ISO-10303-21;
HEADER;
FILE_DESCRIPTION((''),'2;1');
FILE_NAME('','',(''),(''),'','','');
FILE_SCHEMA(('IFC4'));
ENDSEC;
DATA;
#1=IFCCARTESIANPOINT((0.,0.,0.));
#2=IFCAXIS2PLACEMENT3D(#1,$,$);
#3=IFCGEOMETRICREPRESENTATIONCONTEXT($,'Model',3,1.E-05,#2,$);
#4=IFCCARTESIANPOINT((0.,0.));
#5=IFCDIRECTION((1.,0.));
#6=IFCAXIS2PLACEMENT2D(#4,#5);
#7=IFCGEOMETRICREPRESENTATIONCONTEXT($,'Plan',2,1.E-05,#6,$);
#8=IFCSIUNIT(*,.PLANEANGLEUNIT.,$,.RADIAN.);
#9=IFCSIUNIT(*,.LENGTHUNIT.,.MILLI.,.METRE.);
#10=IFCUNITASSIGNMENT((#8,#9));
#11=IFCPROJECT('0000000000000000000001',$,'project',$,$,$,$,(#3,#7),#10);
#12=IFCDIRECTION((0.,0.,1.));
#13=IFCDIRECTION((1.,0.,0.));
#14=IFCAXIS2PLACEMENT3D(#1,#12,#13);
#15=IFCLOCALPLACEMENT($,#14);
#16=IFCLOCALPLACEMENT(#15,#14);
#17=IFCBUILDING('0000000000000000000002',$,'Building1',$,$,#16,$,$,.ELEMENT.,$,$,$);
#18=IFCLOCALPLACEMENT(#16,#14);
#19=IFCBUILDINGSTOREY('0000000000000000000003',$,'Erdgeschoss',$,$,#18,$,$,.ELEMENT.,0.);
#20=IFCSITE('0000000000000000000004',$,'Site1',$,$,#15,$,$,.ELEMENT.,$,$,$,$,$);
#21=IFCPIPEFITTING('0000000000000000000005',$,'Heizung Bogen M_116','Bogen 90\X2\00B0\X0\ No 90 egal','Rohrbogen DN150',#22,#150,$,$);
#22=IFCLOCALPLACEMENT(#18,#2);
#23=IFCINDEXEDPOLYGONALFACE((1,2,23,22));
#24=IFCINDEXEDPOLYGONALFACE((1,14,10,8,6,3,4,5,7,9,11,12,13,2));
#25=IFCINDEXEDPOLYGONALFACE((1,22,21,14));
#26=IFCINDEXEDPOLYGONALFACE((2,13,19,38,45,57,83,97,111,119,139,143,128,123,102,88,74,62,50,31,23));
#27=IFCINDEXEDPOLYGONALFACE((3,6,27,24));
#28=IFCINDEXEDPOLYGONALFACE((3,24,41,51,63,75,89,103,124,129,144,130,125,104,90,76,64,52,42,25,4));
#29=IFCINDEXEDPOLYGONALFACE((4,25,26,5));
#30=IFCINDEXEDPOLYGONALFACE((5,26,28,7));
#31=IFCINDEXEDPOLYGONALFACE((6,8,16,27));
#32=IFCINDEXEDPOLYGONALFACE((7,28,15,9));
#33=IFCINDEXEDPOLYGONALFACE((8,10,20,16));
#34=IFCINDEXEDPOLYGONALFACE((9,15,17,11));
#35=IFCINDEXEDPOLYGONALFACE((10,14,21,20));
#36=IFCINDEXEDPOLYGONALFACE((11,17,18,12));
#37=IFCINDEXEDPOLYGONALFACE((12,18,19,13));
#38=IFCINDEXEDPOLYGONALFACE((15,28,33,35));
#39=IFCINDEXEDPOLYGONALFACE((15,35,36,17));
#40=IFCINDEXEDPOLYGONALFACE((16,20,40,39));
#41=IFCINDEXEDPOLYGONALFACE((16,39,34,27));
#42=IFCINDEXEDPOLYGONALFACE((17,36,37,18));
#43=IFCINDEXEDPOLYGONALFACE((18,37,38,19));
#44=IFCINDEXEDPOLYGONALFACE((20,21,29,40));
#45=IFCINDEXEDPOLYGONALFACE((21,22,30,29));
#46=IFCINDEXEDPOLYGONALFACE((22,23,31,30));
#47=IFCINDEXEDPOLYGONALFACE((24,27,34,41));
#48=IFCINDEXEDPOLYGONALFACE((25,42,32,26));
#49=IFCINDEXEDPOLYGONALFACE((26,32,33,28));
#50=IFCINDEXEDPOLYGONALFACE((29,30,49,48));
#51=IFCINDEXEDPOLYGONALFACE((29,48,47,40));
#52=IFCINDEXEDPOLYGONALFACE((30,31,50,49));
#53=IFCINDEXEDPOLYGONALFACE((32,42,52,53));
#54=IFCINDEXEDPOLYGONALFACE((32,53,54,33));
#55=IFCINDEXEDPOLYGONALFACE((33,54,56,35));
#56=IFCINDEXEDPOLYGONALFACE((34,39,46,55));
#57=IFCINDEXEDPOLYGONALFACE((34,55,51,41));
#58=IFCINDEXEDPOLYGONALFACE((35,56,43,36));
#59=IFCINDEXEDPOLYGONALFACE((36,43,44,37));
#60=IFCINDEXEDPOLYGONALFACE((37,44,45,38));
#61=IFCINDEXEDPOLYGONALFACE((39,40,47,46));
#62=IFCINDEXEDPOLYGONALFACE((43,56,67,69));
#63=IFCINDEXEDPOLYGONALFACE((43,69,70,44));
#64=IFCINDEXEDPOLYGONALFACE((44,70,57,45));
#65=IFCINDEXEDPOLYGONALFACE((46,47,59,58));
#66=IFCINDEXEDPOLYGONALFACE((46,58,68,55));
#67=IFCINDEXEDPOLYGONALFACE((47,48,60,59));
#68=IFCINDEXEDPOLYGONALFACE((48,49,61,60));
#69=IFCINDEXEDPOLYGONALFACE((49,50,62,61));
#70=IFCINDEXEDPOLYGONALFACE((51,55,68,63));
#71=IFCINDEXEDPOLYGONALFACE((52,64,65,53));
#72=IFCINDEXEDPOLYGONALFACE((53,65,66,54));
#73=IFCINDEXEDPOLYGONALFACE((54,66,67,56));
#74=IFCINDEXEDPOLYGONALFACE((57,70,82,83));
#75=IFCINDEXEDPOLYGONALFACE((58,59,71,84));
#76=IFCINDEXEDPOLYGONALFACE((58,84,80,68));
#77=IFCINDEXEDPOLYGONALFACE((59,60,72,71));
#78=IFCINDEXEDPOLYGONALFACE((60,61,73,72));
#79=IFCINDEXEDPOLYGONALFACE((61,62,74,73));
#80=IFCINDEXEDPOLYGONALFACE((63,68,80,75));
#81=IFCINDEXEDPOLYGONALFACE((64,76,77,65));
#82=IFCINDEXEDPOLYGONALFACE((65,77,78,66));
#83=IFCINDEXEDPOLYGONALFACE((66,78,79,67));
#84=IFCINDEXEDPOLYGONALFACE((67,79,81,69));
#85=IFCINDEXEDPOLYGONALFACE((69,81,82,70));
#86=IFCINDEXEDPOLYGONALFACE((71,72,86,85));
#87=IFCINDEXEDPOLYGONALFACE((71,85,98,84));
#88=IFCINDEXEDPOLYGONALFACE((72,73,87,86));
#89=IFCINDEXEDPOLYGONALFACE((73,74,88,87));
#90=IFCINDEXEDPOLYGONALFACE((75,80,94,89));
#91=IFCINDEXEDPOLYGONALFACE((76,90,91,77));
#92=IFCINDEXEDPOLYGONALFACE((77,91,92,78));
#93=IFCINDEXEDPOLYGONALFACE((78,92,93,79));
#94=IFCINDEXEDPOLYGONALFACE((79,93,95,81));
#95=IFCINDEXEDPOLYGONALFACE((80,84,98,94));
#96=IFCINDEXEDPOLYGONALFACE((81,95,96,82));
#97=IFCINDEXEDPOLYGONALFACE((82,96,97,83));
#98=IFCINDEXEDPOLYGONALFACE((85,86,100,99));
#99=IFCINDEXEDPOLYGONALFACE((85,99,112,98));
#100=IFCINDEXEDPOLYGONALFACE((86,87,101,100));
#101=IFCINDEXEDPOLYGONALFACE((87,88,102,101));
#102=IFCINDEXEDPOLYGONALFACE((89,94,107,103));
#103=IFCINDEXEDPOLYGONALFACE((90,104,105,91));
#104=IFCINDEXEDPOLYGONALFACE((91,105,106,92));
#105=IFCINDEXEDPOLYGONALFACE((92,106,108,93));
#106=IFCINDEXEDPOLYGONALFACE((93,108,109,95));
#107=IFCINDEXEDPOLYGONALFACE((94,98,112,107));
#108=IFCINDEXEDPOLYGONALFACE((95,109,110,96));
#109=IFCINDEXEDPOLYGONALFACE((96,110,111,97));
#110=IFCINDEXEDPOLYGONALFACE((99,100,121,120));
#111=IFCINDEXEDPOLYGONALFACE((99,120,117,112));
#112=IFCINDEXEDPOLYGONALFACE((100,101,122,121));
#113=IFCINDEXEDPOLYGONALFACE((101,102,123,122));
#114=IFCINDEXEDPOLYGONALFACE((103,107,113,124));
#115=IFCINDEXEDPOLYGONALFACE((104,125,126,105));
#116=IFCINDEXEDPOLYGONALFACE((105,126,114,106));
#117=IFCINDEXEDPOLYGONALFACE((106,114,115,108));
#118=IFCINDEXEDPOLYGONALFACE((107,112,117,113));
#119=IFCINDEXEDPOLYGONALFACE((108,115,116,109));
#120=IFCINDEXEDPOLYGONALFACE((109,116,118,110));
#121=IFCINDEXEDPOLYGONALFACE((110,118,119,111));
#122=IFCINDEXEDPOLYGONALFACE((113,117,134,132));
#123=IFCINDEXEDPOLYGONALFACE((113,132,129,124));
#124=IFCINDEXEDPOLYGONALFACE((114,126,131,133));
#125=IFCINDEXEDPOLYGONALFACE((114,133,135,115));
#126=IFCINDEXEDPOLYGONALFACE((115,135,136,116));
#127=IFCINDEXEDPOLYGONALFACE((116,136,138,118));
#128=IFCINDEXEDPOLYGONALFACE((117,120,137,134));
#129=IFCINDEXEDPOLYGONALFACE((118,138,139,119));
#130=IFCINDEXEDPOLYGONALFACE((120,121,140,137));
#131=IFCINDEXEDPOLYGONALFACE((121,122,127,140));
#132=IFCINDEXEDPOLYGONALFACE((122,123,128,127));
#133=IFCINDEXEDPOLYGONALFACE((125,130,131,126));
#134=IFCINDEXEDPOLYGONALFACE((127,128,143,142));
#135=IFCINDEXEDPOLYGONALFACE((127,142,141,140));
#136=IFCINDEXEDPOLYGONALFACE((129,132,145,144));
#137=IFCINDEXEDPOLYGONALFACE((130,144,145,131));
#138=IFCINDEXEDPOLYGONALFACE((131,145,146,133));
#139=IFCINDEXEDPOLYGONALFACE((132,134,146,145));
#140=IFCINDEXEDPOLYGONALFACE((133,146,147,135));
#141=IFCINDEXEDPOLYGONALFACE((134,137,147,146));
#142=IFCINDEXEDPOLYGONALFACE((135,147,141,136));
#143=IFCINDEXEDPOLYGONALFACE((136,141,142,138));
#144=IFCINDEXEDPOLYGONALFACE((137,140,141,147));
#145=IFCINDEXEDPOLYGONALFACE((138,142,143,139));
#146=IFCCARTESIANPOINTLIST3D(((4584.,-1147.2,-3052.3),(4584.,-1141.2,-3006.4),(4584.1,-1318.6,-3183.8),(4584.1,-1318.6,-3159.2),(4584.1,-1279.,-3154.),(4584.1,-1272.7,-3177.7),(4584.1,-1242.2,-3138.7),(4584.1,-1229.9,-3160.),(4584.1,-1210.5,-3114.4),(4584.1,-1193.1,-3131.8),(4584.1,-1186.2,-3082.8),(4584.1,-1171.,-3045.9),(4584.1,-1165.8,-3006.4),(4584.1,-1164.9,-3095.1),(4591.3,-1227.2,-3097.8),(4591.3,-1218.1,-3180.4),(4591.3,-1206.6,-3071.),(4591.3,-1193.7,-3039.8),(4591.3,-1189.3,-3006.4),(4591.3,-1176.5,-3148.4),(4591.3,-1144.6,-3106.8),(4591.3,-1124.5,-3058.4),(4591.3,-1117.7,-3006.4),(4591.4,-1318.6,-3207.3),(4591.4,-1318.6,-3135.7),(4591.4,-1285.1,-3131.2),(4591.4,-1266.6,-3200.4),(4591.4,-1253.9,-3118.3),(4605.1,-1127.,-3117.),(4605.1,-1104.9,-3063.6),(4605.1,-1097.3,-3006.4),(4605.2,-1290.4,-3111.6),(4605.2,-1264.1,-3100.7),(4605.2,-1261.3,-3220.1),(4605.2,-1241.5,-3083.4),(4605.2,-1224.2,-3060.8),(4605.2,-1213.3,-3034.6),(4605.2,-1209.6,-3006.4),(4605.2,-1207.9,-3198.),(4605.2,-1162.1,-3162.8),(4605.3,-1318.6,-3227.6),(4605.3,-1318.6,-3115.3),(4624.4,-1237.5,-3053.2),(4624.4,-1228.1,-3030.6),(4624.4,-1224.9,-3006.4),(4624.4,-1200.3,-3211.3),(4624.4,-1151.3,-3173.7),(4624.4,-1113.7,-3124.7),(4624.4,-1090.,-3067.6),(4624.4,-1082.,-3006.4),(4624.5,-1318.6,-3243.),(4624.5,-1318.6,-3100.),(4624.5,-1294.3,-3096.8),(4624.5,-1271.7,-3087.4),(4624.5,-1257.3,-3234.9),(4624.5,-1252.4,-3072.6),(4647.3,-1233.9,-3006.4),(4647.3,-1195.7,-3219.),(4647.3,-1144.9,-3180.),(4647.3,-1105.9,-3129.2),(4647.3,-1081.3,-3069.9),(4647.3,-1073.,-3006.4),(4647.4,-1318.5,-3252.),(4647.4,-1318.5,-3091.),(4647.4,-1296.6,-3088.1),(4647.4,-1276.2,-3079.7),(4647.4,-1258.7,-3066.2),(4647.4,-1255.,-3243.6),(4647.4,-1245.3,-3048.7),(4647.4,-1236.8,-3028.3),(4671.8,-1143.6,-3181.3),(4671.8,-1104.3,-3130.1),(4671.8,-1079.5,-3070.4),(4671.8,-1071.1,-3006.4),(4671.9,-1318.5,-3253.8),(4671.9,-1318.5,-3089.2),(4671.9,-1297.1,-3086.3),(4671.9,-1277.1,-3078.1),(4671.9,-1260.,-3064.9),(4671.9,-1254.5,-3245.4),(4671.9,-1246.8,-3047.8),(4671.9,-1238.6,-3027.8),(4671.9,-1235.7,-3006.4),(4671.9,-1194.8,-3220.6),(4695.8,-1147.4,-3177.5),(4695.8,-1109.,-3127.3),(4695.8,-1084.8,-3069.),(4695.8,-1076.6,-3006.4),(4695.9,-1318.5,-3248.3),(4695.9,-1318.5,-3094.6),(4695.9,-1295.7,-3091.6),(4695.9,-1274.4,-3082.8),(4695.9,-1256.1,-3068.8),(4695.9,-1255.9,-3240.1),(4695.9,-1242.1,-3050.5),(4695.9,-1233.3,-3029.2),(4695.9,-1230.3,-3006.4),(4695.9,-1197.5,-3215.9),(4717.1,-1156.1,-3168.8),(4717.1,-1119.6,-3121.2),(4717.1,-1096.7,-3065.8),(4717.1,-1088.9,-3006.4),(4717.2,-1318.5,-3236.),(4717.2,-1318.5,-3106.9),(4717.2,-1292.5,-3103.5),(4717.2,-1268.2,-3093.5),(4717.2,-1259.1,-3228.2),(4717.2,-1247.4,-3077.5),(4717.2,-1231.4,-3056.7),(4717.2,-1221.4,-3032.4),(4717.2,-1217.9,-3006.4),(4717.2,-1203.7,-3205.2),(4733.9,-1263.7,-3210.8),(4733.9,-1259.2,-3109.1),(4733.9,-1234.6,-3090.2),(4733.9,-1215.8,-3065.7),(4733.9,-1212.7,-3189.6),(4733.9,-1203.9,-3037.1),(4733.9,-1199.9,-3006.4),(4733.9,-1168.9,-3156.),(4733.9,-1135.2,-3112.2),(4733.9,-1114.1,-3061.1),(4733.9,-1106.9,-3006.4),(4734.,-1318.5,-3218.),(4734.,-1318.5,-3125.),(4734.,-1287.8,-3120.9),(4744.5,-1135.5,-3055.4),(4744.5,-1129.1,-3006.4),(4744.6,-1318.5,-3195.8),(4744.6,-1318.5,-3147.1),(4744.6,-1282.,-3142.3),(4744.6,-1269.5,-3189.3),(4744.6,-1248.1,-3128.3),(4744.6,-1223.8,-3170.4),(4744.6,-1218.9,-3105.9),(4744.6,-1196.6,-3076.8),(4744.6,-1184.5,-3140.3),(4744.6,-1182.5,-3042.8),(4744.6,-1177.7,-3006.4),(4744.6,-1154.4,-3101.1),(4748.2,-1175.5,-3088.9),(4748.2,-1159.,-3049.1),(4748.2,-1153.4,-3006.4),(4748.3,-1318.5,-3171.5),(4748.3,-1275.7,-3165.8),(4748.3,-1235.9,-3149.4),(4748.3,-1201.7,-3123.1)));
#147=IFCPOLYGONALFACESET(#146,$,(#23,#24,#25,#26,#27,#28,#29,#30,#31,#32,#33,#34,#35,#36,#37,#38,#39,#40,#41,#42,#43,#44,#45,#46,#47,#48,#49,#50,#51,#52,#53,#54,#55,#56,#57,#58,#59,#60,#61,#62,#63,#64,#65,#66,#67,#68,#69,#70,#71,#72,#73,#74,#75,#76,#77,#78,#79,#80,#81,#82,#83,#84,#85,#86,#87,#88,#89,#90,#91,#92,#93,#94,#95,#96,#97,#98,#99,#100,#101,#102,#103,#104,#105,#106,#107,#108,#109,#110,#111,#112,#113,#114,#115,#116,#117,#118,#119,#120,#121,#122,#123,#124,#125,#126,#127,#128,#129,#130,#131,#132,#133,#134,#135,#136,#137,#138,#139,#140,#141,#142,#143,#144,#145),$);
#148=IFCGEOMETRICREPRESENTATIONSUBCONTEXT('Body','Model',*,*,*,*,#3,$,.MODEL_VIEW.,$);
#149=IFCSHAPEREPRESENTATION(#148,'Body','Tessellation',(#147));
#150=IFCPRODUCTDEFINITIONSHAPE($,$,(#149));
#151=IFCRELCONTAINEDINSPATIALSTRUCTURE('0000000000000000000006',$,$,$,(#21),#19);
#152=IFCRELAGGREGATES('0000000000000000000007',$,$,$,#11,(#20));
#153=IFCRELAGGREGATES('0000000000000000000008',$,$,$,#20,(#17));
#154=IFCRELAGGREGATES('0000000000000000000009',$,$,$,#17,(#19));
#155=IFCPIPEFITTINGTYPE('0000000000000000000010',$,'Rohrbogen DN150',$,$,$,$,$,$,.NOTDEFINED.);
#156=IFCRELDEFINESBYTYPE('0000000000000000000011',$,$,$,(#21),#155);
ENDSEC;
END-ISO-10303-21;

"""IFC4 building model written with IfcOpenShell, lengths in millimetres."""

from ifc_helpers import new_model, entity, si_unit, frame, origin, origin_with_axes, origin_2d_with_axis, place, context, subcontext, project, spatial, source, transform, mapped, type_object, element, save


model = new_model("IFC4")

# Units and contexts
model_context = context("Model", 3, precision=1e-05, world=origin())
plan_context = context("Plan", 2, precision=1e-05, world=origin_2d_with_axis())
body_context = subcontext(model_context, "Body", "Model", "MODEL_VIEW")
ifc_project = project(units=[si_unit("PLANEANGLEUNIT", "RADIAN"), si_unit("LENGTHUNIT", "METRE", prefix="MILLI")], contexts=[model_context, plan_context])

# Site, building, storey
site_placement = place(None, origin_with_axes())
site = spatial("IfcSite", under=ifc_project, at=site_placement, Name="Site1", CompositionType="ELEMENT")
building_placement = place(site_placement, origin_with_axes())
building = spatial("IfcBuilding", under=site, at=building_placement, Name="Building1", CompositionType="ELEMENT")
storey_placement = place(building_placement, origin_with_axes())
storey = spatial("IfcBuildingStorey", under=building, at=storey_placement, Name="Erdgeschoss", CompositionType="ELEMENT", Elevation=0.0)

# Pipe fitting
pipe_fitting_type_1 = type_object("IfcPipeFittingType", Name="Rohrbogen DN150", PredefinedType="NOTDEFINED")
ifc_direction_1 = entity("IfcDirection", [-1.0, 0.0, 0.0])
shared_shape_1 = source(origin_with_axes(), body_context, "Body", "SolidModel", [
    entity("IfcRevolvedAreaSolid", entity("IfcCircleProfileDef", "AREA", None, entity("IfcAxis2Placement2D", entity("IfcCartesianPoint", [0.0, 0.0]), entity("IfcDirection", [1.0, 0.0])), 82.5), entity("IfcAxis2Placement3D", entity("IfcCartesianPoint", [123.8, 0.0, 41.3]), ifc_direction_1, entity("IfcDirection", [0.0, 1.0, 0.000562])), entity("IfcAxis1Placement", entity("IfcCartesianPoint", [0.0, 165.1, 0.0]), ifc_direction_1), 1.570796),
])
pipe_fitting_1_placement = place(storey_placement, frame((4665.7, -1194.7, -3130.2), z_axis=(0.0, 0.0, 1.0), x_axis=(1.0, 0.0, 0.0)))
element("IfcPipeFitting", 1, at=pipe_fitting_1_placement, inside=storey, type_object=pipe_fitting_type_1, Name="Heizung Bogen M_116", Description="Bogen 90° No 90 egal", ObjectType="Rohrbogen DN150", context=body_context, shape_type="MappedRepresentation", body=[
    mapped(shared_shape_1, transform((0.0, 0.0, 0.0), x_axis=(0.0, 0.0, 1.0), y_axis=(1.0, 0.0, 0.0), z_axis=(0.0, 1.0, 0.0), scale=1.0)),
])

save(model, "model.ifc")
